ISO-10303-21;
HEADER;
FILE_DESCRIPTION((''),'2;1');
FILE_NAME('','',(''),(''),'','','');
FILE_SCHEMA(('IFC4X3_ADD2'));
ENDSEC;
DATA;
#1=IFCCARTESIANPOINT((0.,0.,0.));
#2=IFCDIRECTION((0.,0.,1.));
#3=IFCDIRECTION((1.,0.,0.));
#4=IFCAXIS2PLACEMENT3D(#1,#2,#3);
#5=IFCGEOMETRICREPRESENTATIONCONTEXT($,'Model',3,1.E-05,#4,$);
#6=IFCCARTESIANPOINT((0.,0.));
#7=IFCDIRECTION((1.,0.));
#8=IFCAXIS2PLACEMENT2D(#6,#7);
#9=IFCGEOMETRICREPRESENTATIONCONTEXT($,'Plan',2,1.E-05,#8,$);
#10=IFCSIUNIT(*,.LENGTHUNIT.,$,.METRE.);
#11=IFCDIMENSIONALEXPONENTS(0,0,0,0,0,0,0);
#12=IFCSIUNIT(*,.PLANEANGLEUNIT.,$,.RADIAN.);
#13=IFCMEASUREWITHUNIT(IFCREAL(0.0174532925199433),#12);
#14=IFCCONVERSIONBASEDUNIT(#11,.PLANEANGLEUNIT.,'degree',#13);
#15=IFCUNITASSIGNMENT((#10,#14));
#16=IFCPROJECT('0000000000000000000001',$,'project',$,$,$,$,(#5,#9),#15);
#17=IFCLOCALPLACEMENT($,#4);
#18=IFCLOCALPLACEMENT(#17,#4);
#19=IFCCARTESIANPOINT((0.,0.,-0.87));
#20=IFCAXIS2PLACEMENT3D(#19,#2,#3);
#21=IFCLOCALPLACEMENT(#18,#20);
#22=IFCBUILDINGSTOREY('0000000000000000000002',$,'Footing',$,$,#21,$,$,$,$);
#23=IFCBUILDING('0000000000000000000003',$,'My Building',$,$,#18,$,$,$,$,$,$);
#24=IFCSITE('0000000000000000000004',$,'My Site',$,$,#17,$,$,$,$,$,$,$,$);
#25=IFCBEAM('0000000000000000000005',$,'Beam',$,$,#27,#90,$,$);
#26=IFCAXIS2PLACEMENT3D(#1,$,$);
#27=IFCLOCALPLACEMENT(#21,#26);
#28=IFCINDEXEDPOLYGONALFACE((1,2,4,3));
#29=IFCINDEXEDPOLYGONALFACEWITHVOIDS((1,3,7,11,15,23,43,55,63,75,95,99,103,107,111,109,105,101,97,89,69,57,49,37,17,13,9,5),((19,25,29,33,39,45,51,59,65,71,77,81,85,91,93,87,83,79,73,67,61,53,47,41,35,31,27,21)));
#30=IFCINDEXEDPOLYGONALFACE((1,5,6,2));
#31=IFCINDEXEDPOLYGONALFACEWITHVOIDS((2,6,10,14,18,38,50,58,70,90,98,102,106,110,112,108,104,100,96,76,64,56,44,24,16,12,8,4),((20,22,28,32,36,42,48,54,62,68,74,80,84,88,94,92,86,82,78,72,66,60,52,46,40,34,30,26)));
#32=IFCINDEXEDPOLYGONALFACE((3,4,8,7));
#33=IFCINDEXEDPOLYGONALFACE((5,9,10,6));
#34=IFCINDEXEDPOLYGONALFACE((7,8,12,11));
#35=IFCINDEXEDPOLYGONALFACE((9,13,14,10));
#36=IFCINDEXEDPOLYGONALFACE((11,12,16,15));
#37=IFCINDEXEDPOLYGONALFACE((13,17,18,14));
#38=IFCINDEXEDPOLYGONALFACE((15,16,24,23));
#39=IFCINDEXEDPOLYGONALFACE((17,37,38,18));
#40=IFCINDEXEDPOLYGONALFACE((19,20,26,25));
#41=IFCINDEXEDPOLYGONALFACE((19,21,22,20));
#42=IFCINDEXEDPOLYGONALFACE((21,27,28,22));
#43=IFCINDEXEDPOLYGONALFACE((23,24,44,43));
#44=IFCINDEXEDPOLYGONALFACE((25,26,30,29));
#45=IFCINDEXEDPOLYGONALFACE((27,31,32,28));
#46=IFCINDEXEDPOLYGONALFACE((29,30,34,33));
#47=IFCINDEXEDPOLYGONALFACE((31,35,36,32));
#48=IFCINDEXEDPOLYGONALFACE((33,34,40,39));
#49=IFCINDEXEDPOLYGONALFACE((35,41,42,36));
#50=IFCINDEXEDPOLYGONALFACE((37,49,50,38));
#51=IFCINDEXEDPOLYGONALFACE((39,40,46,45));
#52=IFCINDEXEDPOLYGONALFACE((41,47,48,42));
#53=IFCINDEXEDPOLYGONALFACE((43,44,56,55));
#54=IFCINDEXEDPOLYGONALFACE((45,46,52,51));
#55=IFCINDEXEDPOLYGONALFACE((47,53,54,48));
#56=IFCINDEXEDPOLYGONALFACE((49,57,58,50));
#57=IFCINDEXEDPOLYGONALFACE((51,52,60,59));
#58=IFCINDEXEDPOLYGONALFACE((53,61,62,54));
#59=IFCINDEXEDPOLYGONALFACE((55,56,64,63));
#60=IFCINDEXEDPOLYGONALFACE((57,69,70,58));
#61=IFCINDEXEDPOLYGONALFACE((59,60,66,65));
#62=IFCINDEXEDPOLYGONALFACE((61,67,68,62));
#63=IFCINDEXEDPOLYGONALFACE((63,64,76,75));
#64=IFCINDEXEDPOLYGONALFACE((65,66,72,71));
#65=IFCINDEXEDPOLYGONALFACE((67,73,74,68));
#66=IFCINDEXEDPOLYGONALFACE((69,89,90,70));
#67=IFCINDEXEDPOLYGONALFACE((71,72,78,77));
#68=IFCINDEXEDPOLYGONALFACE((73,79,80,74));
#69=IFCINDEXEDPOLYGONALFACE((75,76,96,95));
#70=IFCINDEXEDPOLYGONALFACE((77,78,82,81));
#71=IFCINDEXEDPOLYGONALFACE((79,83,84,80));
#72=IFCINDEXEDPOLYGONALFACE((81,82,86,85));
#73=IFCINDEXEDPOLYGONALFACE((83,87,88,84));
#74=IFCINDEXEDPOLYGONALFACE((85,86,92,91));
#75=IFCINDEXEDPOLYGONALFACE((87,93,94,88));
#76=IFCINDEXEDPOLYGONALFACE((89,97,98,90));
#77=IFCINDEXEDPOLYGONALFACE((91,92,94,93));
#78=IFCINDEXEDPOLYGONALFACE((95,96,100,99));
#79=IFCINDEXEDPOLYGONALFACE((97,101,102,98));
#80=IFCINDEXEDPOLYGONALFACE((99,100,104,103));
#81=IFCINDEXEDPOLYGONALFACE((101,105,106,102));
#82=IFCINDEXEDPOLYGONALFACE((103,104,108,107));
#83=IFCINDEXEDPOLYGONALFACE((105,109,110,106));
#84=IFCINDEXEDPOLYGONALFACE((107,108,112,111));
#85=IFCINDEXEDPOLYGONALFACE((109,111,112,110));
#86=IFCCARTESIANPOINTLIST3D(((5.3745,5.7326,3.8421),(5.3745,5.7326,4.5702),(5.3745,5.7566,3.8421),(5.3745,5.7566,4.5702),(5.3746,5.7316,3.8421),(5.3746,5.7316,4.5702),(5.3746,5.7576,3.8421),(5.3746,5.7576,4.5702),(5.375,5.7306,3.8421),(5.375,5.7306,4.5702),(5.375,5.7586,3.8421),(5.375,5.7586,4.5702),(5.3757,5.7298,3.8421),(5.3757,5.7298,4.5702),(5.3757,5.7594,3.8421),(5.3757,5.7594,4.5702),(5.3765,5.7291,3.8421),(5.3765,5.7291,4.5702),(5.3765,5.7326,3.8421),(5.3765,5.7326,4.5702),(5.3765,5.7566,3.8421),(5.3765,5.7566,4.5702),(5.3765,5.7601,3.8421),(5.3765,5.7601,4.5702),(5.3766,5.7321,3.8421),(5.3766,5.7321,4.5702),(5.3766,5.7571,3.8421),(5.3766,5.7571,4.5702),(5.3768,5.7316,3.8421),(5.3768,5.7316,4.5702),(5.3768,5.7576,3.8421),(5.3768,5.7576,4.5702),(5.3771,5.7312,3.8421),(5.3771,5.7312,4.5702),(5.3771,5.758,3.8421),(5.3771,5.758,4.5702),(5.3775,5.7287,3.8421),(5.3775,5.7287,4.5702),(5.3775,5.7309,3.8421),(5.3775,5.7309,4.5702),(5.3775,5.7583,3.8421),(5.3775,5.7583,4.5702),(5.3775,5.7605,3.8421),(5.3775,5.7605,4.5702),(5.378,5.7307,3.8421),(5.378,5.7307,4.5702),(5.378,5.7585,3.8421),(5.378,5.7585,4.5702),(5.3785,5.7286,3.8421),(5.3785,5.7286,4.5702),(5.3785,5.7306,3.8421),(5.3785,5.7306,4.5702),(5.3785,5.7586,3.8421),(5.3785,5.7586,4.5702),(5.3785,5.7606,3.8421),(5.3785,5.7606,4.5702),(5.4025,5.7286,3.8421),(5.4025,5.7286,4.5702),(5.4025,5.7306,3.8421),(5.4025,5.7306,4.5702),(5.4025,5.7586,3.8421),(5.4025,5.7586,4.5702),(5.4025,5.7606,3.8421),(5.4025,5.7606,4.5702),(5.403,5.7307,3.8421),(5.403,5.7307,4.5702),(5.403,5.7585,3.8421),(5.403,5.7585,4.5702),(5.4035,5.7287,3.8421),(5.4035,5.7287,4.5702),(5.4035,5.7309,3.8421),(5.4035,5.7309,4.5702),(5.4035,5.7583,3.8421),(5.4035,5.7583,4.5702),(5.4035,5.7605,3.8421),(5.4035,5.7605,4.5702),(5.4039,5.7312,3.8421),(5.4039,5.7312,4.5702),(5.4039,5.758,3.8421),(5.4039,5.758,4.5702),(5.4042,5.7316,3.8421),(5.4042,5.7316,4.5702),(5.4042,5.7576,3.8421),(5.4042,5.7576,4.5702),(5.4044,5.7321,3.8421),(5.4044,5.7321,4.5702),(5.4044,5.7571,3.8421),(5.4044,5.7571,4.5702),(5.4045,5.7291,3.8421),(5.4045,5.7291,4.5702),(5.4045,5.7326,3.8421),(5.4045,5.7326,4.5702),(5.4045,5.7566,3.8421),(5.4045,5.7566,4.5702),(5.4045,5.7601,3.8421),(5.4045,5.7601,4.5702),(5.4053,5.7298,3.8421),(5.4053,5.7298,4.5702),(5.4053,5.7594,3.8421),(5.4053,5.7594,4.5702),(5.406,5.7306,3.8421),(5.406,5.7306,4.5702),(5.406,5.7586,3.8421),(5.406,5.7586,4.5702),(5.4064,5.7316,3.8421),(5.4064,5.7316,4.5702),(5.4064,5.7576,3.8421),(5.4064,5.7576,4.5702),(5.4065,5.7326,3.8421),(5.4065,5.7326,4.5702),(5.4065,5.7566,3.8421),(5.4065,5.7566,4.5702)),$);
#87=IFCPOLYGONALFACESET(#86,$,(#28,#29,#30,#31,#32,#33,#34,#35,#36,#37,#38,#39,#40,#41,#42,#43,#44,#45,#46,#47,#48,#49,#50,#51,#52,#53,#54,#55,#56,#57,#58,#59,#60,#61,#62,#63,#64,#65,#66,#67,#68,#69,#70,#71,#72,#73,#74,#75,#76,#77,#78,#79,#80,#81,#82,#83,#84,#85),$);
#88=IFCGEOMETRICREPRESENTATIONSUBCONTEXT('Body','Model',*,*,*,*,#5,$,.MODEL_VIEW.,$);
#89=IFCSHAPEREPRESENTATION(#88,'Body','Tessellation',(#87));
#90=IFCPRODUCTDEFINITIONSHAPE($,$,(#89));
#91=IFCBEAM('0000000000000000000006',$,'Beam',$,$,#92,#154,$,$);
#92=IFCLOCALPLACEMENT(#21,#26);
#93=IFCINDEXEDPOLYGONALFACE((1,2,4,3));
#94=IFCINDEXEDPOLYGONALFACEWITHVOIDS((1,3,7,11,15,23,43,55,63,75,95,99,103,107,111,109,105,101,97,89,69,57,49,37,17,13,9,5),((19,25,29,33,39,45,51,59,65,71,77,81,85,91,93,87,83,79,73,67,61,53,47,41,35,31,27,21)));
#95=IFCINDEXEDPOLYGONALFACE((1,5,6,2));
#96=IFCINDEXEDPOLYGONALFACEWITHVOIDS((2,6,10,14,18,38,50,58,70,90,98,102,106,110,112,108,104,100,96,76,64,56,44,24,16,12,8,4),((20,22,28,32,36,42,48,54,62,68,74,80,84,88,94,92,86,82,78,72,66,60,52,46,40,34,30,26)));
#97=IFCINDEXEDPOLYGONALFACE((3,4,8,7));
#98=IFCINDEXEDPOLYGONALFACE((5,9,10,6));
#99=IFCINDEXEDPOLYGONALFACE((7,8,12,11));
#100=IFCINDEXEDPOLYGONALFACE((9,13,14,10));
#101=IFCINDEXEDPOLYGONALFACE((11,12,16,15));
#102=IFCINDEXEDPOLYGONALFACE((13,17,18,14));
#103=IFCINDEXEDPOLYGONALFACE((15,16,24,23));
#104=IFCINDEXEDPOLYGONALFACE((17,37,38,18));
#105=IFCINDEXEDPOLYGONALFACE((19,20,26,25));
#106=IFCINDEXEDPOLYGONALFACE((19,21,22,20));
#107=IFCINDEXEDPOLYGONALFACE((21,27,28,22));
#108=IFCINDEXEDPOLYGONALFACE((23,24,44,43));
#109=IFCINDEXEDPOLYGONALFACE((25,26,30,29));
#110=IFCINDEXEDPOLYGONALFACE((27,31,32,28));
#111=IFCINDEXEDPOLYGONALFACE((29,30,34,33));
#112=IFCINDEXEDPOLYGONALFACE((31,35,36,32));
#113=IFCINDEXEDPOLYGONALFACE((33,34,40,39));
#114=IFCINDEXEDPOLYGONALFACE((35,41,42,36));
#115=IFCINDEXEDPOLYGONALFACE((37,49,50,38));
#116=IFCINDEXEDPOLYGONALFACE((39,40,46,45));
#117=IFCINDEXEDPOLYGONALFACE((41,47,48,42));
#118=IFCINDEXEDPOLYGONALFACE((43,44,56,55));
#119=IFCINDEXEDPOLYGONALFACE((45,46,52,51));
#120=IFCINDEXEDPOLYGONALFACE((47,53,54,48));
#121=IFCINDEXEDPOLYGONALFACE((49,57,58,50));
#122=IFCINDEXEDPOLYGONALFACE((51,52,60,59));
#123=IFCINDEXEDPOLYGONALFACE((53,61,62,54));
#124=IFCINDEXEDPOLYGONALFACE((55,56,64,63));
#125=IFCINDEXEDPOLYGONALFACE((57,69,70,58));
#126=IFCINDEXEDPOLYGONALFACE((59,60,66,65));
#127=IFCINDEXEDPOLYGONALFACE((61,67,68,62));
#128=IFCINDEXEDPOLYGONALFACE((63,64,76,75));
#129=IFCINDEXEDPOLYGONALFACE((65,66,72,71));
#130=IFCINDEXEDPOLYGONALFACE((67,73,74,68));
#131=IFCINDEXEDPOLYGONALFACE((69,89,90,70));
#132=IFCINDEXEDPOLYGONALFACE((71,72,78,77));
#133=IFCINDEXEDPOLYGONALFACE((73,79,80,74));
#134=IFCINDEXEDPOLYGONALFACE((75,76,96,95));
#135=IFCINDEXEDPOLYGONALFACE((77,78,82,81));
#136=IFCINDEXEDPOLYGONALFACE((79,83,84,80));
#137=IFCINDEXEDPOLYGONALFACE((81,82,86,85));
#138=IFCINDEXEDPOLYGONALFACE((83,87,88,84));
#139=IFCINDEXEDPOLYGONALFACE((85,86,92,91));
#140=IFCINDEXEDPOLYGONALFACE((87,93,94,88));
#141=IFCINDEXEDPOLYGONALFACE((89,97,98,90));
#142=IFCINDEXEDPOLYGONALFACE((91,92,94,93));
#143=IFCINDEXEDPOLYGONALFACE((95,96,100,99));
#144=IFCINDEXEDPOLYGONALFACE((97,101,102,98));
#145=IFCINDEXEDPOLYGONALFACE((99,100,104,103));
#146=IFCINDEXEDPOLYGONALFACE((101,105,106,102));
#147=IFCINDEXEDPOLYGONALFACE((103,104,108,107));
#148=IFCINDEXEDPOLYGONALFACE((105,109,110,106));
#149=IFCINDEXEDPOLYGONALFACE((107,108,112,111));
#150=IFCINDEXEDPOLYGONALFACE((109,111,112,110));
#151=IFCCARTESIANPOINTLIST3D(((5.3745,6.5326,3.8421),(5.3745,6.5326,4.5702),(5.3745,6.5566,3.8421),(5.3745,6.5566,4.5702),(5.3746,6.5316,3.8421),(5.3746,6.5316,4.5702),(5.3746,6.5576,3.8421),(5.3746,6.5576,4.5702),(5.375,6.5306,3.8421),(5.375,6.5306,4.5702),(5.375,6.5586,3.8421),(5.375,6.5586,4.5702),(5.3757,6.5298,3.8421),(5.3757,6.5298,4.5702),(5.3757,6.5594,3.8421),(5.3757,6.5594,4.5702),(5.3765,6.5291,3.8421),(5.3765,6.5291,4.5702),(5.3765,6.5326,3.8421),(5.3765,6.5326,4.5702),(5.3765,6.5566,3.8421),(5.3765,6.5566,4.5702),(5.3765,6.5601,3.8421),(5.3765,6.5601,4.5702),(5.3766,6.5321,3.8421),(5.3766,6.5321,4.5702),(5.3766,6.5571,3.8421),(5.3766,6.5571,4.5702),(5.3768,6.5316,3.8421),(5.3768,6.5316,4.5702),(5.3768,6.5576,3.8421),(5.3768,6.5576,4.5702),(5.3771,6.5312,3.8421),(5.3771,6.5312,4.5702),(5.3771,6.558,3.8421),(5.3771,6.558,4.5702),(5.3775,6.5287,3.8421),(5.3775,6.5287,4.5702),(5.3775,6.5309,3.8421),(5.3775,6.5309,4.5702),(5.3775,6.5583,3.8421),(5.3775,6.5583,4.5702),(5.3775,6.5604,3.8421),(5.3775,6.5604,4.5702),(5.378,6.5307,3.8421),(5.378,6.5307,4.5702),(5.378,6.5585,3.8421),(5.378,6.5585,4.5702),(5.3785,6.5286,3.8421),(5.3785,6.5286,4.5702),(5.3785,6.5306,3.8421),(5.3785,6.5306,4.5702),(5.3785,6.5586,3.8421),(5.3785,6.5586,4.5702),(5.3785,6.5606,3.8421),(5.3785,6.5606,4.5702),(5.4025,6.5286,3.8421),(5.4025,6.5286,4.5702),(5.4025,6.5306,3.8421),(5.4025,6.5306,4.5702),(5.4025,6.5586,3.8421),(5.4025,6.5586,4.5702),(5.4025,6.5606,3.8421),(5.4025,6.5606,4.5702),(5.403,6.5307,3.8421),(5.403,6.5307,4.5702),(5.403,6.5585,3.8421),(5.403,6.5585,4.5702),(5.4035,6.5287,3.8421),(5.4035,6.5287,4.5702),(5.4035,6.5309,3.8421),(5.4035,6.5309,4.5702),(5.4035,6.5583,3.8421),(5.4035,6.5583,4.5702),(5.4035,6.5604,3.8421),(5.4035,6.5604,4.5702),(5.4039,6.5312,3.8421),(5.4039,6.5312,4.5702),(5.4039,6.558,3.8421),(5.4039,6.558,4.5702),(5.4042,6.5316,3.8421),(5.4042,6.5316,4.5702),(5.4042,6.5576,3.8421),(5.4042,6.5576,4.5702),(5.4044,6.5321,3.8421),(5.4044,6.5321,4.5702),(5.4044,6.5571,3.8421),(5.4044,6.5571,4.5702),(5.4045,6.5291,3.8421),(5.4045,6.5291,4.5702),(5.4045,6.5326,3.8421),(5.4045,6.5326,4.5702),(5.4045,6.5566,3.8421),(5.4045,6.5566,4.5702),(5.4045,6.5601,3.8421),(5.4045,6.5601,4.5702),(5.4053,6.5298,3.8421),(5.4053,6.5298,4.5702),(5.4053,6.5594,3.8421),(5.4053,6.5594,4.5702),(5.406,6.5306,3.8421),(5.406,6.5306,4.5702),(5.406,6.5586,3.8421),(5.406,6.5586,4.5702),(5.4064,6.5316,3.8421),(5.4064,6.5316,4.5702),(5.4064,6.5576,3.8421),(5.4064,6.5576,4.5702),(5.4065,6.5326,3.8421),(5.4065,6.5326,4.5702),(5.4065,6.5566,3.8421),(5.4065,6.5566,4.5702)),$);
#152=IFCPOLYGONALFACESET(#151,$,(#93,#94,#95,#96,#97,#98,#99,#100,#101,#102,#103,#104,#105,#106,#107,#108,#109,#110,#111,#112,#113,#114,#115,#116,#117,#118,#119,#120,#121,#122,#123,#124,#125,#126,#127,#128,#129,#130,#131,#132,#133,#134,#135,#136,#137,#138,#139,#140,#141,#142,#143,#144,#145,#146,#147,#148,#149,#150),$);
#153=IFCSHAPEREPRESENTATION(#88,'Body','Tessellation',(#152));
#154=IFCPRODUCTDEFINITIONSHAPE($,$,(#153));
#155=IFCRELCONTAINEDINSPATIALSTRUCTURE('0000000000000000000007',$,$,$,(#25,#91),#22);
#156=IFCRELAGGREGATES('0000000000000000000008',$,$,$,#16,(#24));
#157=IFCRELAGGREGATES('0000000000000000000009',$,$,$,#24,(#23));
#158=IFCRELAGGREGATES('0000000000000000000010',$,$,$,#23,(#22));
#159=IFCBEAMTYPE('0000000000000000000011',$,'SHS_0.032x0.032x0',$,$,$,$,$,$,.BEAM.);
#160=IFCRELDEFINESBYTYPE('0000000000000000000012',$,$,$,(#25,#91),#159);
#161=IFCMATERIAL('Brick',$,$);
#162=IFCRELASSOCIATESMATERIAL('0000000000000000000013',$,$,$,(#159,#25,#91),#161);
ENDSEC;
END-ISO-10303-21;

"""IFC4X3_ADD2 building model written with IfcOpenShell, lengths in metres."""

from ifc_helpers import new_model, entity, si_unit, converted_unit, frame, origin_with_axes, origin_2d_with_axis, place, context, subcontext, project, spatial, hollow_rectangle, extrude, material, material_profile, profile_set, profile_usage, type_object, element, save


model = new_model("IFC4X3_ADD2")

# Units and contexts
model_context = context("Model", 3, precision=1e-05, world=origin_with_axes())
plan_context = context("Plan", 2, precision=1e-05, world=origin_2d_with_axis())
body_context = subcontext(model_context, "Body", "Model", "MODEL_VIEW")
ifc_project = project(units=[si_unit("LENGTHUNIT", "METRE"), converted_unit("PLANEANGLEUNIT", "degree", entity("IfcReal", 0.0174532925199433), si_unit("PLANEANGLEUNIT", "RADIAN"), dimensions=[0, 0, 0, 0, 0, 0, 0])], contexts=[model_context, plan_context])

# Site, building, storey
site_placement = place(None, origin_with_axes())
site = spatial("IfcSite", under=ifc_project, at=site_placement, Name="My Site")
building_placement = place(site_placement, origin_with_axes())
building = spatial("IfcBuilding", under=site, at=building_placement, Name="My Building")
storey_placement = place(building_placement, frame((0.0, 0.0, -0.87), z_axis=(0.0, 0.0, 1.0), x_axis=(1.0, 0.0, 0.0)))
storey = spatial("IfcBuildingStorey", under=building, at=storey_placement, Name="Footing")

# Beams
ifc_material_1 = material(Name="Brick")
ifc_material_profile = material_profile(ifc_material_1, hollow_rectangle(XDim=0.032, YDim=0.032, WallThickness=0.002, InnerFilletRadius=0.002, OuterFilletRadius=0.004))
ifc_profile_set = profile_set([ifc_material_profile])
beam_type_1 = type_object("IfcBeamType", Name="SHS_0.032x0.032x0", PredefinedType="BEAM", material=ifc_profile_set)
ifc_profile_usage_1 = profile_usage(ifc_profile_set, cardinal=5)
beam_1_placement = place(storey_placement, frame((5.3905, 5.7446, 3.8421), z_axis=(0.0, 0.0, 1.0), x_axis=(1.0, 0.0, 0.0)))
element("IfcBeam", 1, at=beam_1_placement, inside=storey, type_object=beam_type_1, material=ifc_profile_usage_1, Name="Beam", context=body_context, shape_type="SweptSolid", body=[
    extrude(hollow_rectangle(XDim=0.032, YDim=0.032, WallThickness=0.002, InnerFilletRadius=0.002, OuterFilletRadius=0.004), origin_with_axes(), (0.0, 0.0, 1.0), 0.7281),
])
ifc_profile_usage_2 = profile_usage(ifc_profile_set, cardinal=5)
beam_2_placement = place(storey_placement, frame((5.3905, 6.5446, 3.8421), z_axis=(0.0, 0.0, 1.0), x_axis=(1.0, 0.0, 0.0)))
element("IfcBeam", 2, at=beam_2_placement, inside=storey, type_object=beam_type_1, material=ifc_profile_usage_2, Name="Beam", context=body_context, shape_type="SweptSolid", body=[
    extrude(hollow_rectangle(XDim=0.032, YDim=0.032, WallThickness=0.002, InnerFilletRadius=0.002, OuterFilletRadius=0.004), origin_with_axes(), (0.0, 0.0, 1.0), 0.7281),
])

save(model, "model.ifc")
